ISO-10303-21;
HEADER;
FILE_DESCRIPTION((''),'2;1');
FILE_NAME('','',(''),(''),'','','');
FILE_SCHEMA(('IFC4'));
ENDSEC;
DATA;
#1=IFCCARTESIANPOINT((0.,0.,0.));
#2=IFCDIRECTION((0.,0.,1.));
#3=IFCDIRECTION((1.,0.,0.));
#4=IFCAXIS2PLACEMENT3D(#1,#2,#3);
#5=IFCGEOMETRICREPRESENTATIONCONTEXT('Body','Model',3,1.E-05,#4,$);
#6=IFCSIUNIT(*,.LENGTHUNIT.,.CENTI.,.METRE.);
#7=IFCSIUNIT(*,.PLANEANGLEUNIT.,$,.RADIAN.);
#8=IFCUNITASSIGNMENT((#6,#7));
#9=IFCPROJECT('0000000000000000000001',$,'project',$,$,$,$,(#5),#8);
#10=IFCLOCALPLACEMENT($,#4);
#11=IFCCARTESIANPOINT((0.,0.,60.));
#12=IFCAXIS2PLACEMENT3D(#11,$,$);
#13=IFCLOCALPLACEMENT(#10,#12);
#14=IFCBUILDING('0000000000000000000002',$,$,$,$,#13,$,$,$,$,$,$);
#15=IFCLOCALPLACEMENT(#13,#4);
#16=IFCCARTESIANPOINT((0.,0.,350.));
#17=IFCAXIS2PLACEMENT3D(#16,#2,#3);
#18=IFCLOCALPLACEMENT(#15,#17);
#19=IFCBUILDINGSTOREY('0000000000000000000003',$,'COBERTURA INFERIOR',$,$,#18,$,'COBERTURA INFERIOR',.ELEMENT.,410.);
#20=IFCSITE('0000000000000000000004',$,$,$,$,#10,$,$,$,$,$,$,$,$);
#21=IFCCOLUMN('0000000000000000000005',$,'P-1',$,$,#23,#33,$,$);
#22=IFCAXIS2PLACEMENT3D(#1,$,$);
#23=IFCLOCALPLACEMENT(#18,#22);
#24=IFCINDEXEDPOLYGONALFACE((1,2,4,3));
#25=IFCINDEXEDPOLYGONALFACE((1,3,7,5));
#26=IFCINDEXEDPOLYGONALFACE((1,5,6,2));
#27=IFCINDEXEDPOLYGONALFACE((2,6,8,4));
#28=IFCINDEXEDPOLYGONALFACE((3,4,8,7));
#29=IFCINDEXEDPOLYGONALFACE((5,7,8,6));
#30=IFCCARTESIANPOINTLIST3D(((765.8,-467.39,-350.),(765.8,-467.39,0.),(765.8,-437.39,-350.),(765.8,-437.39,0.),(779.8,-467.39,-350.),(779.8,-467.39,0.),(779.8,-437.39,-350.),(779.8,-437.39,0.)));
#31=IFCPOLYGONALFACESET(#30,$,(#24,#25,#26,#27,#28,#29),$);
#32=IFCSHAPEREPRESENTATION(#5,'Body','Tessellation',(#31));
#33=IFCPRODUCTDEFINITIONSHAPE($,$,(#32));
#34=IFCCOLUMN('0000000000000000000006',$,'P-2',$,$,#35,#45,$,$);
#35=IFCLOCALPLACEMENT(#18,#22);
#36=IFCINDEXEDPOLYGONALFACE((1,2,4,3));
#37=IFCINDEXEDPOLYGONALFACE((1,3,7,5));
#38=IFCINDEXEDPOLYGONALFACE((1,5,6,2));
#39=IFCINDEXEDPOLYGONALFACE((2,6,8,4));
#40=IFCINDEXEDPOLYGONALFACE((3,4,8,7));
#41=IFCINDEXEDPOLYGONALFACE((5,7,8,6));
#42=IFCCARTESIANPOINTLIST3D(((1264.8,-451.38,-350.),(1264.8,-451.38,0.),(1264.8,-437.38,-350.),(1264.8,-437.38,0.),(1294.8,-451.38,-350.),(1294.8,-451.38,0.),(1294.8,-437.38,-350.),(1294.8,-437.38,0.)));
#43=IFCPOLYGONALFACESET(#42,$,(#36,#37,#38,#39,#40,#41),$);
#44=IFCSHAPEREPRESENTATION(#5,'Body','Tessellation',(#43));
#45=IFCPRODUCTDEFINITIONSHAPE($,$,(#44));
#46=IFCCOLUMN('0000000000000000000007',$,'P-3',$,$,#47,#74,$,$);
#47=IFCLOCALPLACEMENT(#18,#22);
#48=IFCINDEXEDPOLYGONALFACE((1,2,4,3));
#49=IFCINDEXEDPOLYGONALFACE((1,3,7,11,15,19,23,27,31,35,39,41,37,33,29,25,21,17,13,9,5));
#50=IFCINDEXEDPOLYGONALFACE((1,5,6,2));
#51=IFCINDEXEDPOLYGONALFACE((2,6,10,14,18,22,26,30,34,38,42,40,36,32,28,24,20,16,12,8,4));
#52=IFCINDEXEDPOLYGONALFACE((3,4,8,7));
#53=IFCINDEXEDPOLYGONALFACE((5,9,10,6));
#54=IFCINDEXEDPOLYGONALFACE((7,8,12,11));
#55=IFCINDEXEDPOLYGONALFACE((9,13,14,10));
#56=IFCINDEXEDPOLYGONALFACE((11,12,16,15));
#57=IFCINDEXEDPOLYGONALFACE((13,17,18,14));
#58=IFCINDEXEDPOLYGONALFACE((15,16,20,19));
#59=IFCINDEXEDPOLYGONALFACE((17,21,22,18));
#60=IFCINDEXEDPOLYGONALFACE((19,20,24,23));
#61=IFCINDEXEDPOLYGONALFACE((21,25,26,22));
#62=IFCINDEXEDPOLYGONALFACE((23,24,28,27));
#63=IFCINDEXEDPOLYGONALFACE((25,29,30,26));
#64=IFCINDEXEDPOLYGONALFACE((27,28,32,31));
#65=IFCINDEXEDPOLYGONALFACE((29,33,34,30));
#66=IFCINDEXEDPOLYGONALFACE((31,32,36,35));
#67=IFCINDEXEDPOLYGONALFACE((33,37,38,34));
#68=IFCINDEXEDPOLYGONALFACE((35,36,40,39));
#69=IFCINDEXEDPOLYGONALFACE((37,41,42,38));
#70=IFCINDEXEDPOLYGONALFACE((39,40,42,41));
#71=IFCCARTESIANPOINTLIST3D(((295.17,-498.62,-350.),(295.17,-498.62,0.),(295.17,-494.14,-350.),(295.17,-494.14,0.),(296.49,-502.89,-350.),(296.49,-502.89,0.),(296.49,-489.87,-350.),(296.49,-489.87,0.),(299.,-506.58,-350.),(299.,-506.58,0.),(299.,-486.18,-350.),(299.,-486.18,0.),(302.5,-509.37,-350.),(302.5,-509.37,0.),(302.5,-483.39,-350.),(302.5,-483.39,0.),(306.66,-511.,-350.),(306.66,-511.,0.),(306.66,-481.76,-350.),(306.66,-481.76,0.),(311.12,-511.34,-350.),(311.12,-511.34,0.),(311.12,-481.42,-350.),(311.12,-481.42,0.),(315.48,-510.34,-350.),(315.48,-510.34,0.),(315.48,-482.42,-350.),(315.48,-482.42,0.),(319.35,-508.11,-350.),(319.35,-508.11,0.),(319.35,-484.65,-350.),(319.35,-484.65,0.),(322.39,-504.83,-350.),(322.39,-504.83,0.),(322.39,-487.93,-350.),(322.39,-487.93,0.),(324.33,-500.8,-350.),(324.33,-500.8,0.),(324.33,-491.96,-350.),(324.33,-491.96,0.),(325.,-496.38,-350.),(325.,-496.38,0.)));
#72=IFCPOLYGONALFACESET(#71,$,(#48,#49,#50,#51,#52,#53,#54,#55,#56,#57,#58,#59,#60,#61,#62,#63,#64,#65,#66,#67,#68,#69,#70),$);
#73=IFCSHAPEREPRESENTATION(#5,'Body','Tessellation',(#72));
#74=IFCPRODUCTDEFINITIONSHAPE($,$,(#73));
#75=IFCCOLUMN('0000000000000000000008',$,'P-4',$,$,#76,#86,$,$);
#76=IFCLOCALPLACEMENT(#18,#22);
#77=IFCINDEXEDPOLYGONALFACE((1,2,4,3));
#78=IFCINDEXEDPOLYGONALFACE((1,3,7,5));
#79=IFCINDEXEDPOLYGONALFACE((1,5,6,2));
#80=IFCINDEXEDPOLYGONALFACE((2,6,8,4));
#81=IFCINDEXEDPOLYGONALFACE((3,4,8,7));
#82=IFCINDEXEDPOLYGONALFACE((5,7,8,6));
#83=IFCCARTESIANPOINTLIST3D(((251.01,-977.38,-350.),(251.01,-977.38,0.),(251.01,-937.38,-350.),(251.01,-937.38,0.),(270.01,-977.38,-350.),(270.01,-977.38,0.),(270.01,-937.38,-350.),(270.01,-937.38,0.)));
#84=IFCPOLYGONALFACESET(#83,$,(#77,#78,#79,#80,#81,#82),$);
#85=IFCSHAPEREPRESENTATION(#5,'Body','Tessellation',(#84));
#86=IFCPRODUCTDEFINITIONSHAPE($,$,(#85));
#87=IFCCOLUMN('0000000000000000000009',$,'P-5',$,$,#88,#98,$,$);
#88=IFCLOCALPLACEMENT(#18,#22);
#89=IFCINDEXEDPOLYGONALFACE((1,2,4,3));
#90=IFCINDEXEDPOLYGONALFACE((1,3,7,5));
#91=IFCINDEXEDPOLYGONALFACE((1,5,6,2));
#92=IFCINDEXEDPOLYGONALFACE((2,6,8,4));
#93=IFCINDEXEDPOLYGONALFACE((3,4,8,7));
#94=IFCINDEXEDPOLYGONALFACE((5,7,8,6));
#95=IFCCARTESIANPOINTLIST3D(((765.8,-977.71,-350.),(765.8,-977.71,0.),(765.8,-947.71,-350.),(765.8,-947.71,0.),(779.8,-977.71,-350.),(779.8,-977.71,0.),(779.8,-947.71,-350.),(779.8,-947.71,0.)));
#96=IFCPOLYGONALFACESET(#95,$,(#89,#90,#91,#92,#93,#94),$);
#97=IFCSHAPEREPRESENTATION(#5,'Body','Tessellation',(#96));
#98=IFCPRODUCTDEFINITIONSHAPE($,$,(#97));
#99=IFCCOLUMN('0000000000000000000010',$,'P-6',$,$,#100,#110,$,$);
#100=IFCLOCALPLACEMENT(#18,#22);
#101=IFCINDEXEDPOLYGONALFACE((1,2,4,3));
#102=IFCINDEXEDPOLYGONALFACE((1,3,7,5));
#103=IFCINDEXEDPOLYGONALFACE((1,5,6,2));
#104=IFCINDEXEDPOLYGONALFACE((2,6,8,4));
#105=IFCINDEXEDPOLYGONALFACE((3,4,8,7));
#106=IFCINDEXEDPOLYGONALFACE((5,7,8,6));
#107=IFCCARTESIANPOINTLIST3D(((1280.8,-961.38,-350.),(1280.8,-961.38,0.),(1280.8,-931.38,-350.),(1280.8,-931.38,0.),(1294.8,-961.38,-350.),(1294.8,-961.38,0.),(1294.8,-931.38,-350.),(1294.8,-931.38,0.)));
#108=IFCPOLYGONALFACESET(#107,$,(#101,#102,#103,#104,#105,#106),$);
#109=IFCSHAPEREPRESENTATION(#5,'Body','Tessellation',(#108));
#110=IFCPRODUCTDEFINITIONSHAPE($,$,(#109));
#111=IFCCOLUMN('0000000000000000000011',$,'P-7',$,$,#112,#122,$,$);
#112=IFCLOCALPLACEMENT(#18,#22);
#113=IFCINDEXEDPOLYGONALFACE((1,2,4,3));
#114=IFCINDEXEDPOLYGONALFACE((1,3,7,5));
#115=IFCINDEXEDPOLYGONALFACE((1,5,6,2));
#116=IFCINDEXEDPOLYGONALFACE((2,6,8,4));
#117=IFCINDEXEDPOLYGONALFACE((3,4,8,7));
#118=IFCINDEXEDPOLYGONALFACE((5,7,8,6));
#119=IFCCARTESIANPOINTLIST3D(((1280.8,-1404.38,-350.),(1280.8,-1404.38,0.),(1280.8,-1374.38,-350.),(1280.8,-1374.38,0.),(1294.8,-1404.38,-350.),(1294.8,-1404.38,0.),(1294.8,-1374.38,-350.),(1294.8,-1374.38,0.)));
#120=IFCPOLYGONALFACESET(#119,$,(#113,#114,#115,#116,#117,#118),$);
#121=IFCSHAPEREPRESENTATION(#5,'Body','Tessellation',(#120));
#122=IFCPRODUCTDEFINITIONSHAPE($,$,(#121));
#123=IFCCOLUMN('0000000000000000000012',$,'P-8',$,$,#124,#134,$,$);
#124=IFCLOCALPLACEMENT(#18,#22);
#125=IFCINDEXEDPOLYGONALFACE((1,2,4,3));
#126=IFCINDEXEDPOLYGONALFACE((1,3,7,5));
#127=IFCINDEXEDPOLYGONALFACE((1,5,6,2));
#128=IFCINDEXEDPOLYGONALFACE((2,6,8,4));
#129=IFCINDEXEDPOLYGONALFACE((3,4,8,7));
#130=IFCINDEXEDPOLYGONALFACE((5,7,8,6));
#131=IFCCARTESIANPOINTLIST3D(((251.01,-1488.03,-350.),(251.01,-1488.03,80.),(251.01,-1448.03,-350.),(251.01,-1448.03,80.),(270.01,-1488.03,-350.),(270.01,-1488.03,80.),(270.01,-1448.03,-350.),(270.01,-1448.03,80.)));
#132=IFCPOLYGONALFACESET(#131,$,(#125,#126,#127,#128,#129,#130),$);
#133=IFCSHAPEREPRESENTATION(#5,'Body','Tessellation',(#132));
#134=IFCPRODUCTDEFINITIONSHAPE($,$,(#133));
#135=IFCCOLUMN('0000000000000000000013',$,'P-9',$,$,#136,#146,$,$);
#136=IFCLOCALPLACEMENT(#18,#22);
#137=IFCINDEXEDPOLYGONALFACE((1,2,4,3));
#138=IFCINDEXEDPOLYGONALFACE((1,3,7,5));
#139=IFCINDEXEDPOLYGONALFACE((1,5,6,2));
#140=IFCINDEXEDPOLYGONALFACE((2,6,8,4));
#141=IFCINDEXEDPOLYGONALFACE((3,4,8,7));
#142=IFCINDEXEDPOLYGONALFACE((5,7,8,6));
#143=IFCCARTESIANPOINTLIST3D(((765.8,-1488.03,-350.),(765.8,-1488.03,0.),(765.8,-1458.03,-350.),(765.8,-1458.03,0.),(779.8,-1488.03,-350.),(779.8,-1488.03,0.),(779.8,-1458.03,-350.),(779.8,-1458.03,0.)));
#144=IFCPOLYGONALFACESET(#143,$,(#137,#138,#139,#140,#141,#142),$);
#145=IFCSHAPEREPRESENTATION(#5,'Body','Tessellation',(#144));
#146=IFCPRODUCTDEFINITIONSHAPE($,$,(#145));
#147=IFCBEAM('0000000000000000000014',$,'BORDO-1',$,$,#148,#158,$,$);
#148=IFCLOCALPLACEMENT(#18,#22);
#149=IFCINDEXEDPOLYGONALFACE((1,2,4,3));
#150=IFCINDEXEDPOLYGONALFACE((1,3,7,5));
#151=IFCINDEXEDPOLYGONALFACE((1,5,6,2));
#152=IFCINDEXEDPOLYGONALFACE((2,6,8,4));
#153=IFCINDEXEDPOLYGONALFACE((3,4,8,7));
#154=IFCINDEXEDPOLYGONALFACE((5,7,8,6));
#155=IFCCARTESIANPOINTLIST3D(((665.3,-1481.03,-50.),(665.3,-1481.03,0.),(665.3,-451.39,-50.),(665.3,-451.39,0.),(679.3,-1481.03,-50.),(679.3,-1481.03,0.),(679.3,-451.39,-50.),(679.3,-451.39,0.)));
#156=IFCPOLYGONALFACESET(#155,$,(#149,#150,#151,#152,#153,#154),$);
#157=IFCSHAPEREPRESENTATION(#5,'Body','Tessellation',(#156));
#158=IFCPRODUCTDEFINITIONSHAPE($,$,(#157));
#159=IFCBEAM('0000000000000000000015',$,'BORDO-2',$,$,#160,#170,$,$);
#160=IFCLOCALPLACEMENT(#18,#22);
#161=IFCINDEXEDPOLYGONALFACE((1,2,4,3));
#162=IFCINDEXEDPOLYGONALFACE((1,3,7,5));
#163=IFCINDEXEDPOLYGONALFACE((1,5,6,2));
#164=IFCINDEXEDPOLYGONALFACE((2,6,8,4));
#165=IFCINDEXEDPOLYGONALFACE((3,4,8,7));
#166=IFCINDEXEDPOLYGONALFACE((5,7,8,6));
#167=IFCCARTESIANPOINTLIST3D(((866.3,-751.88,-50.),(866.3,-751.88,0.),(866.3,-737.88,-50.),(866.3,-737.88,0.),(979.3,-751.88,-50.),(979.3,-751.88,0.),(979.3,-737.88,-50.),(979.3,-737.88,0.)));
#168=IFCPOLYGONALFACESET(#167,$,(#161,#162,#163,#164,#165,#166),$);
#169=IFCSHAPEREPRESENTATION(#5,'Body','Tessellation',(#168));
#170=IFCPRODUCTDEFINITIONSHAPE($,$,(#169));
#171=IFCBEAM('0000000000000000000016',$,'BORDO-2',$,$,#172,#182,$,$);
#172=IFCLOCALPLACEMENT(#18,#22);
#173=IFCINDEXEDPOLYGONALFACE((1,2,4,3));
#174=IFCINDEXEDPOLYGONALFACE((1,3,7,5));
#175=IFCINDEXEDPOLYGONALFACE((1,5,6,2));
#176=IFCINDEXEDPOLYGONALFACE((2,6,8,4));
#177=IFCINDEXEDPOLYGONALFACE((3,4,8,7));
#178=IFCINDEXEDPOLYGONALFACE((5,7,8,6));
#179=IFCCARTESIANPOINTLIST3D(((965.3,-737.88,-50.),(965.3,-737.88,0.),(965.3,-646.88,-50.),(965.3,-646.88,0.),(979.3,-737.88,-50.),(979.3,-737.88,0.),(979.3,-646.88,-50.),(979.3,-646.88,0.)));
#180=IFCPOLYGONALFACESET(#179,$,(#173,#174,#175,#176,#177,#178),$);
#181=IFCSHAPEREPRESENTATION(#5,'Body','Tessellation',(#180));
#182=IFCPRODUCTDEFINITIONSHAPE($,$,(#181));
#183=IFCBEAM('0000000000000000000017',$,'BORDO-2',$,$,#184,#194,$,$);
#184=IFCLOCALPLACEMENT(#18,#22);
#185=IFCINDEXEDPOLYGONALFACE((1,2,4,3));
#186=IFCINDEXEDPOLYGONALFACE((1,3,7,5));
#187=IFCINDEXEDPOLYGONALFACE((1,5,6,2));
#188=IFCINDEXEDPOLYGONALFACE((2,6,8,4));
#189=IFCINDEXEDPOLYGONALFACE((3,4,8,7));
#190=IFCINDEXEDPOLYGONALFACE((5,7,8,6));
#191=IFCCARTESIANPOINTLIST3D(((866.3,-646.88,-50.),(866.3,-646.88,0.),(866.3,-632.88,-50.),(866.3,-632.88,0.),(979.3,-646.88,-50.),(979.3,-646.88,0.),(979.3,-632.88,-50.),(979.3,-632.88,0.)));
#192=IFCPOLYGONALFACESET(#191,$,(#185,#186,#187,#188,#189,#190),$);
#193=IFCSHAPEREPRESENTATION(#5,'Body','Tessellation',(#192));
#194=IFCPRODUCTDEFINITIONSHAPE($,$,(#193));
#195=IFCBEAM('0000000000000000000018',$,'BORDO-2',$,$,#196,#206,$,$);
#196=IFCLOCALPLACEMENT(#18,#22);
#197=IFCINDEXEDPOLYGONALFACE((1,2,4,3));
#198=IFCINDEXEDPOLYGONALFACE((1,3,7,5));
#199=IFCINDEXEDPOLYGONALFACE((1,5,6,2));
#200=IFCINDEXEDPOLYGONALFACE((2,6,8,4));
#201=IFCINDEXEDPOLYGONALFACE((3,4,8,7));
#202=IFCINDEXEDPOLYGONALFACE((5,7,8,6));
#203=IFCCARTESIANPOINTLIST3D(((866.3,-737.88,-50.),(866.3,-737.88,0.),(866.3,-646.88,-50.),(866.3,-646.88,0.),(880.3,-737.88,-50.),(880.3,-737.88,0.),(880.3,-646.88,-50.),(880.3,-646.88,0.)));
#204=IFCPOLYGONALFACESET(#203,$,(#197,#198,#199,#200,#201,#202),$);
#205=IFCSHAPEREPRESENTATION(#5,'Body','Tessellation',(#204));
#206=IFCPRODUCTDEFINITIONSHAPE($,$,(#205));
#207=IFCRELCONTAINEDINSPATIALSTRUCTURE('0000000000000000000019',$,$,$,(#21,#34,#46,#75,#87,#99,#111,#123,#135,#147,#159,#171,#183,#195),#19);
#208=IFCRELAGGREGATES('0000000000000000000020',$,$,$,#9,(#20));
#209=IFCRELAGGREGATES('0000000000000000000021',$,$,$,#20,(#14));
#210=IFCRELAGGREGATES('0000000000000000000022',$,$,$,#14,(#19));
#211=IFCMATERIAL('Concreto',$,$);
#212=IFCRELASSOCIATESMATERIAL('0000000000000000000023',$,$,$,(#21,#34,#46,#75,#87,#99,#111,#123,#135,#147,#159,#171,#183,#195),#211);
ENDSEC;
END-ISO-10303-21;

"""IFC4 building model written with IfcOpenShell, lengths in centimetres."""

from ifc_helpers import new_model, si_unit, frame, origin_with_axes, origin_2d_with_axis, place, context, project, spatial, rectangle, circle, extrude, material, element, save


model = new_model("IFC4")

# Units and contexts
model_context = context("Model", 3, precision=1e-05, world=origin_with_axes(), identifier="Body")
ifc_project = project(units=[si_unit("LENGTHUNIT", "METRE", prefix="CENTI"), si_unit("PLANEANGLEUNIT", "RADIAN")], contexts=[model_context])

# Site, building, storey
site_placement = place(None, origin_with_axes())
site = spatial("IfcSite", under=ifc_project, at=site_placement)
building_placement = place(site_placement, frame((0.0, 0.0, 60.0)))
building = spatial("IfcBuilding", under=site, at=building_placement)
placement = place(building_placement, origin_with_axes())
storey_placement = place(placement, frame((0.0, 0.0, 350.0), z_axis=(0.0, 0.0, 1.0), x_axis=(1.0, 0.0, 0.0)))
storey = spatial("IfcBuildingStorey", under=building, at=storey_placement, Name="COBERTURA INFERIOR", LongName="COBERTURA INFERIOR", CompositionType="ELEMENT", Elevation=410.0)

# Columns
ifc_material = material(Name="Concreto")
column_1_placement = place(storey_placement, frame((772.8, -452.39, 0.0), z_axis=(0.0, 0.0, 1.0), x_axis=(1.0, 0.0, 0.0)))
element("IfcColumn", 1, at=column_1_placement, inside=storey, material=ifc_material, Name="P-1", context=model_context, shape_type="SolidModel", body=[
    extrude(rectangle(XDim=14.0, YDim=30.0, at=origin_2d_with_axis()), origin_with_axes(), (0.0, 0.0, -1.0), 350.0),
])
column_2_placement = place(storey_placement, frame((1279.8, -444.38, 0.0), z_axis=(0.0, 0.0, 1.0), x_axis=(1.0, 0.0, 0.0)))
element("IfcColumn", 2, at=column_2_placement, inside=storey, material=ifc_material, Name="P-2", context=model_context, shape_type="SolidModel", body=[
    extrude(rectangle(XDim=14.0, YDim=30.0, at=origin_2d_with_axis()), frame((0.0, 0.0, 0.0), z_axis=(0.0, 0.0, 1.0), x_axis=(0.0, -1.0, 0.0)), (0.0, 0.0, -1.0), 350.0),
])
column_3_placement = place(storey_placement, frame((310.0, -496.38, 0.0), z_axis=(0.0, 0.0, 1.0), x_axis=(1.0, 0.0, 0.0)))
element("IfcColumn", 3, at=column_3_placement, inside=storey, material=ifc_material, Name="P-3", context=model_context, shape_type="SolidModel", body=[
    extrude(circle(Radius=15.0, at=origin_2d_with_axis()), origin_with_axes(), (0.0, 0.0, -1.0), 350.0),
])
column_4_placement = place(storey_placement, frame((260.51, -957.38, 0.0), z_axis=(0.0, 0.0, 1.0), x_axis=(1.0, 0.0, 0.0)))
element("IfcColumn", 4, at=column_4_placement, inside=storey, material=ifc_material, Name="P-4", context=model_context, shape_type="SolidModel", body=[
    extrude(rectangle(XDim=19.0, YDim=40.0, at=origin_2d_with_axis()), origin_with_axes(), (0.0, 0.0, -1.0), 350.0),
])
for number, where, z_axis, x_axis, name in (
    (5, (772.8, -962.71, 0.0), (0.0, 0.0, 1.0), (1.0, 0.0, 0.0), "P-5"),
    (6, (1287.8, -946.38, 0.0), (0.0, 0.0, 1.0), (1.0, 0.0, 0.0), "P-6"),
    (7, (1287.8, -1389.38, 0.0), (0.0, 0.0, 1.0), (1.0, 0.0, 0.0), "P-7"),
):
    element("IfcColumn", number, at=place(storey_placement, frame(where, z_axis=z_axis, x_axis=x_axis)), inside=storey, material=ifc_material, Name=name, context=model_context, shape_type="SolidModel", body=[
        extrude(rectangle(XDim=14.0, YDim=30.0, at=origin_2d_with_axis()), origin_with_axes(), (0.0, 0.0, -1.0), 350.0),
    ])
column_5_placement = place(storey_placement, frame((260.51, -1468.03, 80.0), z_axis=(0.0, 0.0, 1.0), x_axis=(1.0, 0.0, 0.0)))
element("IfcColumn", 8, at=column_5_placement, inside=storey, material=ifc_material, Name="P-8", context=model_context, shape_type="SolidModel", body=[
    extrude(rectangle(XDim=19.0, YDim=40.0, at=origin_2d_with_axis()), origin_with_axes(), (0.0, 0.0, -1.0), 430.0),
])
column_6_placement = place(storey_placement, frame((772.8, -1473.03, 0.0), z_axis=(0.0, 0.0, 1.0), x_axis=(1.0, 0.0, 0.0)))
element("IfcColumn", 9, at=column_6_placement, inside=storey, material=ifc_material, Name="P-9", context=model_context, shape_type="SolidModel", body=[
    extrude(rectangle(XDim=14.0, YDim=30.0, at=origin_2d_with_axis()), origin_with_axes(), (0.0, 0.0, -1.0), 350.0),
])

# Beams
beam_1_placement = place(storey_placement, frame((672.3, -966.21, 0.0), z_axis=(0.0, 0.0, 1.0), x_axis=(1.0, 0.0, 0.0)))
element("IfcBeam", 10, at=beam_1_placement, inside=storey, material=ifc_material, Name="BORDO-1", context=model_context, shape_type="SolidModel", body=[
    extrude(rectangle(XDim=14.0, YDim=50.0, at=origin_2d_with_axis()), frame((0.0, -514.82, -25.0), z_axis=(0.0, 1.0, 0.0), x_axis=(1.0, 0.0, 0.0)), (0.0, 0.0, 1.0), 1029.64),
])
beam_2_placement = place(storey_placement, frame((922.8, -744.88, 0.0), z_axis=(0.0, 0.0, 1.0), x_axis=(1.0, 0.0, 0.0)))
element("IfcBeam", 11, at=beam_2_placement, inside=storey, material=ifc_material, Name="BORDO-2", context=model_context, shape_type="SolidModel", body=[
    extrude(rectangle(XDim=14.0, YDim=50.0, at=origin_2d_with_axis()), frame((56.5, 0.0, -25.0), z_axis=(-1.0, 0.0, 0.0), x_axis=(0.0, -1.0, 0.0)), (0.0, 0.0, 1.0), 113.0),
])
beam_3_placement = place(storey_placement, frame((972.3, -692.38, 0.0), z_axis=(0.0, 0.0, 1.0), x_axis=(1.0, 0.0, 0.0)))
element("IfcBeam", 12, at=beam_3_placement, inside=storey, material=ifc_material, Name="BORDO-2", context=model_context, shape_type="SolidModel", body=[
    extrude(rectangle(XDim=14.0, YDim=50.0, at=origin_2d_with_axis()), frame((0.0, 45.5, -25.0), z_axis=(0.0, -1.0, 0.0), x_axis=(1.0, 0.0, 0.0)), (0.0, 0.0, 1.0), 91.0),
])
beam_4_placement = place(storey_placement, frame((922.8, -639.88, 0.0), z_axis=(0.0, 0.0, 1.0), x_axis=(1.0, 0.0, 0.0)))
element("IfcBeam", 13, at=beam_4_placement, inside=storey, material=ifc_material, Name="BORDO-2", context=model_context, shape_type="SolidModel", body=[
    extrude(rectangle(XDim=14.0, YDim=50.0, at=origin_2d_with_axis()), frame((-56.5, 0.0, -25.0), z_axis=(1.0, 0.0, 0.0), x_axis=(0.0, -1.0, 0.0)), (0.0, 0.0, 1.0), 113.0),
])
beam_5_placement = place(storey_placement, frame((873.3, -692.38, 0.0), z_axis=(0.0, 0.0, 1.0), x_axis=(1.0, 0.0, 0.0)))
element("IfcBeam", 14, at=beam_5_placement, inside=storey, material=ifc_material, Name="BORDO-2", context=model_context, shape_type="SolidModel", body=[
    extrude(rectangle(XDim=14.0, YDim=50.0, at=origin_2d_with_axis()), frame((0.0, -45.5, -25.0), z_axis=(0.0, 1.0, 0.0), x_axis=(1.0, 0.0, 0.0)), (0.0, 0.0, 1.0), 91.0),
])

save(model, "model.ifc")
